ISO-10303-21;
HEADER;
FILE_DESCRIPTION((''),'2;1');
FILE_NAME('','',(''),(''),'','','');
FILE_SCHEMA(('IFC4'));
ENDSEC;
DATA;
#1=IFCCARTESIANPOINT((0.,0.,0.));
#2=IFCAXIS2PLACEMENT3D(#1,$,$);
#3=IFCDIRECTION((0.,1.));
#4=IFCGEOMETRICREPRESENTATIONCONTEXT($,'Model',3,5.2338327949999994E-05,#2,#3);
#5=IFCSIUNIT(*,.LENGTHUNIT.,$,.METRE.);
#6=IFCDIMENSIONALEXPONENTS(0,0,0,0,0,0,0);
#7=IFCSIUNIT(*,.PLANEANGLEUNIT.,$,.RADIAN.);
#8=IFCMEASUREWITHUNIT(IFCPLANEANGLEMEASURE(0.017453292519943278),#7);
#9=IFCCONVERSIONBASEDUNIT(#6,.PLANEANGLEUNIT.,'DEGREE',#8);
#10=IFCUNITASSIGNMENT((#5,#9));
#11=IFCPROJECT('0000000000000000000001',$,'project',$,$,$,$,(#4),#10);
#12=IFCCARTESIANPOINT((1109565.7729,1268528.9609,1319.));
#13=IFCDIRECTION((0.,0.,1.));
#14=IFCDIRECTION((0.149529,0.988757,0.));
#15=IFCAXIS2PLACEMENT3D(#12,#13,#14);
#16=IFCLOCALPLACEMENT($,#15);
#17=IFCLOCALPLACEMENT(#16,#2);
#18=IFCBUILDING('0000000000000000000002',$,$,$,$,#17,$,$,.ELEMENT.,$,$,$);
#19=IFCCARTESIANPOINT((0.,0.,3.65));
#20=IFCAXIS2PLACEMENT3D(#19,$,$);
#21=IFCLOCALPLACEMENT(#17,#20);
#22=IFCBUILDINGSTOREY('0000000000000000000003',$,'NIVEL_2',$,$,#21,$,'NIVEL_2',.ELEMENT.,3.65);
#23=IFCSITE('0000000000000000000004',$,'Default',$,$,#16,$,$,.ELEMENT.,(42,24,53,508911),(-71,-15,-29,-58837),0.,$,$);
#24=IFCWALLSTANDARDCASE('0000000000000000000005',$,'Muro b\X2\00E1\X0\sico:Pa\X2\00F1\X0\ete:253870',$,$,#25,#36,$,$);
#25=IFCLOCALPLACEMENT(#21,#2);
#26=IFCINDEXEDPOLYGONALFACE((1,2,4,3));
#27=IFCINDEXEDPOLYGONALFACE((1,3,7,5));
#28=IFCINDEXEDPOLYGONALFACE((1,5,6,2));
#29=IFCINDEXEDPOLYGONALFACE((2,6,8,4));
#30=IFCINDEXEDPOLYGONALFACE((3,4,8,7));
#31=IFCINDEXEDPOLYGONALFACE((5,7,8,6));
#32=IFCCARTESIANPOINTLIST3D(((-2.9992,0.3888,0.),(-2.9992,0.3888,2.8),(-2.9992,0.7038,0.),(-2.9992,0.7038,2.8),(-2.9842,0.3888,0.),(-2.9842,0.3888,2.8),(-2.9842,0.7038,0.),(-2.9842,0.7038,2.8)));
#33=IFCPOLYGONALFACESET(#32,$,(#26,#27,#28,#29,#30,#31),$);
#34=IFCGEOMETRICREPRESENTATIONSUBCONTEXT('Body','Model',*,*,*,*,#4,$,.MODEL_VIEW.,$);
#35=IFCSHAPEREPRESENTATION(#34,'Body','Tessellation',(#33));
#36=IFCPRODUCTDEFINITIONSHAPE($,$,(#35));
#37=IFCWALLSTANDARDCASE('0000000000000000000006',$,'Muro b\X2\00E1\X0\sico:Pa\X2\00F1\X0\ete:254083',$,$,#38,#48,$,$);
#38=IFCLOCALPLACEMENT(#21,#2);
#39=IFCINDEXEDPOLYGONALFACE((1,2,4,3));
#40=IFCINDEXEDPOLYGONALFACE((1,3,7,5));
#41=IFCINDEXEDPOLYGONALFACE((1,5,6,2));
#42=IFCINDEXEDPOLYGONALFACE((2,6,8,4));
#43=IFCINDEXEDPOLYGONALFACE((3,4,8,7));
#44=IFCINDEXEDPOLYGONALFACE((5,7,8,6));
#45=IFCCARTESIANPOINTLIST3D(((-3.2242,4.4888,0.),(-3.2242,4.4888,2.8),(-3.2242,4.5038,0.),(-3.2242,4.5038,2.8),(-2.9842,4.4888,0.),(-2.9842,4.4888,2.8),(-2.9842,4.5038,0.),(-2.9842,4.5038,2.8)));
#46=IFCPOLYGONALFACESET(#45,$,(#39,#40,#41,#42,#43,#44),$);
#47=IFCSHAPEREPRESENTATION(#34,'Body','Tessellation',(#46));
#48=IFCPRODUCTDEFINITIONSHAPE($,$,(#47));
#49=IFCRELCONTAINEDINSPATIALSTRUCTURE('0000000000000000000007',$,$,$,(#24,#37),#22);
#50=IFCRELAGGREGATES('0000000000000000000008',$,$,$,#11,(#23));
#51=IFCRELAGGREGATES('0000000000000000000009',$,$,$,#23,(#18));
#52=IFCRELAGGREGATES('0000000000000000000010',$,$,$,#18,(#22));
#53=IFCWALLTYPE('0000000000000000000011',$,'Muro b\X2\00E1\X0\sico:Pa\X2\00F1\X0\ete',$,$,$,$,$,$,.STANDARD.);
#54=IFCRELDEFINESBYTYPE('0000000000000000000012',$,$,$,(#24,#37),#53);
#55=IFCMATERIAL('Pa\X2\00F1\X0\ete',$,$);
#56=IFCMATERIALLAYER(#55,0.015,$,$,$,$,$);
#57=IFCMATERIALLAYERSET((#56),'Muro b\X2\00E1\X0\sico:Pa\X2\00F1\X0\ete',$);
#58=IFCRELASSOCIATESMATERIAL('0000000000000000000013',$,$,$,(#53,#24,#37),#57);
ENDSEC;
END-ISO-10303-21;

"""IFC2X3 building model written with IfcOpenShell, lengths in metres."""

from ifc_helpers import new_model, entity, si_unit, converted_unit, direction, frame, frame_2d, origin, place, context, subcontext, project, spatial, rectangle, extrude, material, layer, layer_set, layer_usage, type_object, element, save


model = new_model("IFC2X3")

# Units and contexts
model_context = context("Model", 3, precision=5.2338327949999994e-05, world=origin(), true_north=direction((0.0, 1.0)))
body_context = subcontext(model_context, "Body", "Model", "MODEL_VIEW")
ifc_project = project(units=[si_unit("LENGTHUNIT", "METRE"), converted_unit("PLANEANGLEUNIT", "DEGREE", entity("IfcPlaneAngleMeasure", 0.017453292519943278), si_unit("PLANEANGLEUNIT", "RADIAN"), dimensions=[0, 0, 0, 0, 0, 0, 0])], contexts=[model_context])

# Site, building, storey
site_placement = place(None, frame((1109565.7729, 1268528.9609, 1319.0), z_axis=(0.0, 0.0, 1.0), x_axis=(0.149529, 0.988757, 0.0)))
site = spatial("IfcSite", under=ifc_project, at=site_placement, Name="Default", CompositionType="ELEMENT", RefLatitude=(42, 24, 53, 508911), RefLongitude=(-71, -15, -29, -58837), RefElevation=0.0)
building_placement = place(site_placement, origin())
building = spatial("IfcBuilding", under=site, at=building_placement, CompositionType="ELEMENT")
storey_placement = place(building_placement, frame((0.0, 0.0, 3.65)))
storey = spatial("IfcBuildingStorey", under=building, at=storey_placement, Name="NIVEL_2", LongName="NIVEL_2", CompositionType="ELEMENT", Elevation=3.65)

# Shared definitions
ifc_material_1 = material(Name="Pañete")

# Wall
ifc_layer_1 = layer(ifc_material_1, 0.015)
ifc_layer_set_1 = layer_set([ifc_layer_1], Name="Muro básico:Pañete")
wall_type_1 = type_object("IfcWallType", Name="Muro básico:Pañete", PredefinedType="STANDARD", material=ifc_layer_set_1)
ifc_layer_usage_1 = layer_usage(ifc_layer_set_1, "AXIS2", "NEGATIVE", 0.0075)
wall_1_placement = place(storey_placement, frame((-2.9917, 0.7038, 0.0), z_axis=(0.0, 0.0, 1.0), x_axis=(0.0, -1.0, 0.0)))
element("IfcWallStandardCase", 1, at=wall_1_placement, inside=storey, type_object=wall_type_1, material=ifc_layer_usage_1, Name="Muro básico:Pañete:253870", context=body_context, shape_type="SweptSolid", body=[
    extrude(rectangle(XDim=0.315, YDim=0.015, at=frame_2d((0.1575, 0.0), x_axis=(-1.0, 0.0))), origin(), (0.0, 0.0, 1.0), 2.8),
])

# Wall
ifc_layer_usage_2 = layer_usage(ifc_layer_set_1, "AXIS2", "POSITIVE", -0.0075)
wall_2_placement = place(storey_placement, frame((-3.2242, 4.4963, 0.0)))
element("IfcWallStandardCase", 2, at=wall_2_placement, inside=storey, type_object=wall_type_1, material=ifc_layer_usage_2, Name="Muro básico:Pañete:254083", context=body_context, shape_type="SweptSolid", body=[
    extrude(rectangle(XDim=0.24, YDim=0.015, at=frame_2d((0.12, 0.0), x_axis=(-1.0, 0.0))), origin(), (0.0, 0.0, 1.0), 2.8),
])

save(model, "model.ifc")
